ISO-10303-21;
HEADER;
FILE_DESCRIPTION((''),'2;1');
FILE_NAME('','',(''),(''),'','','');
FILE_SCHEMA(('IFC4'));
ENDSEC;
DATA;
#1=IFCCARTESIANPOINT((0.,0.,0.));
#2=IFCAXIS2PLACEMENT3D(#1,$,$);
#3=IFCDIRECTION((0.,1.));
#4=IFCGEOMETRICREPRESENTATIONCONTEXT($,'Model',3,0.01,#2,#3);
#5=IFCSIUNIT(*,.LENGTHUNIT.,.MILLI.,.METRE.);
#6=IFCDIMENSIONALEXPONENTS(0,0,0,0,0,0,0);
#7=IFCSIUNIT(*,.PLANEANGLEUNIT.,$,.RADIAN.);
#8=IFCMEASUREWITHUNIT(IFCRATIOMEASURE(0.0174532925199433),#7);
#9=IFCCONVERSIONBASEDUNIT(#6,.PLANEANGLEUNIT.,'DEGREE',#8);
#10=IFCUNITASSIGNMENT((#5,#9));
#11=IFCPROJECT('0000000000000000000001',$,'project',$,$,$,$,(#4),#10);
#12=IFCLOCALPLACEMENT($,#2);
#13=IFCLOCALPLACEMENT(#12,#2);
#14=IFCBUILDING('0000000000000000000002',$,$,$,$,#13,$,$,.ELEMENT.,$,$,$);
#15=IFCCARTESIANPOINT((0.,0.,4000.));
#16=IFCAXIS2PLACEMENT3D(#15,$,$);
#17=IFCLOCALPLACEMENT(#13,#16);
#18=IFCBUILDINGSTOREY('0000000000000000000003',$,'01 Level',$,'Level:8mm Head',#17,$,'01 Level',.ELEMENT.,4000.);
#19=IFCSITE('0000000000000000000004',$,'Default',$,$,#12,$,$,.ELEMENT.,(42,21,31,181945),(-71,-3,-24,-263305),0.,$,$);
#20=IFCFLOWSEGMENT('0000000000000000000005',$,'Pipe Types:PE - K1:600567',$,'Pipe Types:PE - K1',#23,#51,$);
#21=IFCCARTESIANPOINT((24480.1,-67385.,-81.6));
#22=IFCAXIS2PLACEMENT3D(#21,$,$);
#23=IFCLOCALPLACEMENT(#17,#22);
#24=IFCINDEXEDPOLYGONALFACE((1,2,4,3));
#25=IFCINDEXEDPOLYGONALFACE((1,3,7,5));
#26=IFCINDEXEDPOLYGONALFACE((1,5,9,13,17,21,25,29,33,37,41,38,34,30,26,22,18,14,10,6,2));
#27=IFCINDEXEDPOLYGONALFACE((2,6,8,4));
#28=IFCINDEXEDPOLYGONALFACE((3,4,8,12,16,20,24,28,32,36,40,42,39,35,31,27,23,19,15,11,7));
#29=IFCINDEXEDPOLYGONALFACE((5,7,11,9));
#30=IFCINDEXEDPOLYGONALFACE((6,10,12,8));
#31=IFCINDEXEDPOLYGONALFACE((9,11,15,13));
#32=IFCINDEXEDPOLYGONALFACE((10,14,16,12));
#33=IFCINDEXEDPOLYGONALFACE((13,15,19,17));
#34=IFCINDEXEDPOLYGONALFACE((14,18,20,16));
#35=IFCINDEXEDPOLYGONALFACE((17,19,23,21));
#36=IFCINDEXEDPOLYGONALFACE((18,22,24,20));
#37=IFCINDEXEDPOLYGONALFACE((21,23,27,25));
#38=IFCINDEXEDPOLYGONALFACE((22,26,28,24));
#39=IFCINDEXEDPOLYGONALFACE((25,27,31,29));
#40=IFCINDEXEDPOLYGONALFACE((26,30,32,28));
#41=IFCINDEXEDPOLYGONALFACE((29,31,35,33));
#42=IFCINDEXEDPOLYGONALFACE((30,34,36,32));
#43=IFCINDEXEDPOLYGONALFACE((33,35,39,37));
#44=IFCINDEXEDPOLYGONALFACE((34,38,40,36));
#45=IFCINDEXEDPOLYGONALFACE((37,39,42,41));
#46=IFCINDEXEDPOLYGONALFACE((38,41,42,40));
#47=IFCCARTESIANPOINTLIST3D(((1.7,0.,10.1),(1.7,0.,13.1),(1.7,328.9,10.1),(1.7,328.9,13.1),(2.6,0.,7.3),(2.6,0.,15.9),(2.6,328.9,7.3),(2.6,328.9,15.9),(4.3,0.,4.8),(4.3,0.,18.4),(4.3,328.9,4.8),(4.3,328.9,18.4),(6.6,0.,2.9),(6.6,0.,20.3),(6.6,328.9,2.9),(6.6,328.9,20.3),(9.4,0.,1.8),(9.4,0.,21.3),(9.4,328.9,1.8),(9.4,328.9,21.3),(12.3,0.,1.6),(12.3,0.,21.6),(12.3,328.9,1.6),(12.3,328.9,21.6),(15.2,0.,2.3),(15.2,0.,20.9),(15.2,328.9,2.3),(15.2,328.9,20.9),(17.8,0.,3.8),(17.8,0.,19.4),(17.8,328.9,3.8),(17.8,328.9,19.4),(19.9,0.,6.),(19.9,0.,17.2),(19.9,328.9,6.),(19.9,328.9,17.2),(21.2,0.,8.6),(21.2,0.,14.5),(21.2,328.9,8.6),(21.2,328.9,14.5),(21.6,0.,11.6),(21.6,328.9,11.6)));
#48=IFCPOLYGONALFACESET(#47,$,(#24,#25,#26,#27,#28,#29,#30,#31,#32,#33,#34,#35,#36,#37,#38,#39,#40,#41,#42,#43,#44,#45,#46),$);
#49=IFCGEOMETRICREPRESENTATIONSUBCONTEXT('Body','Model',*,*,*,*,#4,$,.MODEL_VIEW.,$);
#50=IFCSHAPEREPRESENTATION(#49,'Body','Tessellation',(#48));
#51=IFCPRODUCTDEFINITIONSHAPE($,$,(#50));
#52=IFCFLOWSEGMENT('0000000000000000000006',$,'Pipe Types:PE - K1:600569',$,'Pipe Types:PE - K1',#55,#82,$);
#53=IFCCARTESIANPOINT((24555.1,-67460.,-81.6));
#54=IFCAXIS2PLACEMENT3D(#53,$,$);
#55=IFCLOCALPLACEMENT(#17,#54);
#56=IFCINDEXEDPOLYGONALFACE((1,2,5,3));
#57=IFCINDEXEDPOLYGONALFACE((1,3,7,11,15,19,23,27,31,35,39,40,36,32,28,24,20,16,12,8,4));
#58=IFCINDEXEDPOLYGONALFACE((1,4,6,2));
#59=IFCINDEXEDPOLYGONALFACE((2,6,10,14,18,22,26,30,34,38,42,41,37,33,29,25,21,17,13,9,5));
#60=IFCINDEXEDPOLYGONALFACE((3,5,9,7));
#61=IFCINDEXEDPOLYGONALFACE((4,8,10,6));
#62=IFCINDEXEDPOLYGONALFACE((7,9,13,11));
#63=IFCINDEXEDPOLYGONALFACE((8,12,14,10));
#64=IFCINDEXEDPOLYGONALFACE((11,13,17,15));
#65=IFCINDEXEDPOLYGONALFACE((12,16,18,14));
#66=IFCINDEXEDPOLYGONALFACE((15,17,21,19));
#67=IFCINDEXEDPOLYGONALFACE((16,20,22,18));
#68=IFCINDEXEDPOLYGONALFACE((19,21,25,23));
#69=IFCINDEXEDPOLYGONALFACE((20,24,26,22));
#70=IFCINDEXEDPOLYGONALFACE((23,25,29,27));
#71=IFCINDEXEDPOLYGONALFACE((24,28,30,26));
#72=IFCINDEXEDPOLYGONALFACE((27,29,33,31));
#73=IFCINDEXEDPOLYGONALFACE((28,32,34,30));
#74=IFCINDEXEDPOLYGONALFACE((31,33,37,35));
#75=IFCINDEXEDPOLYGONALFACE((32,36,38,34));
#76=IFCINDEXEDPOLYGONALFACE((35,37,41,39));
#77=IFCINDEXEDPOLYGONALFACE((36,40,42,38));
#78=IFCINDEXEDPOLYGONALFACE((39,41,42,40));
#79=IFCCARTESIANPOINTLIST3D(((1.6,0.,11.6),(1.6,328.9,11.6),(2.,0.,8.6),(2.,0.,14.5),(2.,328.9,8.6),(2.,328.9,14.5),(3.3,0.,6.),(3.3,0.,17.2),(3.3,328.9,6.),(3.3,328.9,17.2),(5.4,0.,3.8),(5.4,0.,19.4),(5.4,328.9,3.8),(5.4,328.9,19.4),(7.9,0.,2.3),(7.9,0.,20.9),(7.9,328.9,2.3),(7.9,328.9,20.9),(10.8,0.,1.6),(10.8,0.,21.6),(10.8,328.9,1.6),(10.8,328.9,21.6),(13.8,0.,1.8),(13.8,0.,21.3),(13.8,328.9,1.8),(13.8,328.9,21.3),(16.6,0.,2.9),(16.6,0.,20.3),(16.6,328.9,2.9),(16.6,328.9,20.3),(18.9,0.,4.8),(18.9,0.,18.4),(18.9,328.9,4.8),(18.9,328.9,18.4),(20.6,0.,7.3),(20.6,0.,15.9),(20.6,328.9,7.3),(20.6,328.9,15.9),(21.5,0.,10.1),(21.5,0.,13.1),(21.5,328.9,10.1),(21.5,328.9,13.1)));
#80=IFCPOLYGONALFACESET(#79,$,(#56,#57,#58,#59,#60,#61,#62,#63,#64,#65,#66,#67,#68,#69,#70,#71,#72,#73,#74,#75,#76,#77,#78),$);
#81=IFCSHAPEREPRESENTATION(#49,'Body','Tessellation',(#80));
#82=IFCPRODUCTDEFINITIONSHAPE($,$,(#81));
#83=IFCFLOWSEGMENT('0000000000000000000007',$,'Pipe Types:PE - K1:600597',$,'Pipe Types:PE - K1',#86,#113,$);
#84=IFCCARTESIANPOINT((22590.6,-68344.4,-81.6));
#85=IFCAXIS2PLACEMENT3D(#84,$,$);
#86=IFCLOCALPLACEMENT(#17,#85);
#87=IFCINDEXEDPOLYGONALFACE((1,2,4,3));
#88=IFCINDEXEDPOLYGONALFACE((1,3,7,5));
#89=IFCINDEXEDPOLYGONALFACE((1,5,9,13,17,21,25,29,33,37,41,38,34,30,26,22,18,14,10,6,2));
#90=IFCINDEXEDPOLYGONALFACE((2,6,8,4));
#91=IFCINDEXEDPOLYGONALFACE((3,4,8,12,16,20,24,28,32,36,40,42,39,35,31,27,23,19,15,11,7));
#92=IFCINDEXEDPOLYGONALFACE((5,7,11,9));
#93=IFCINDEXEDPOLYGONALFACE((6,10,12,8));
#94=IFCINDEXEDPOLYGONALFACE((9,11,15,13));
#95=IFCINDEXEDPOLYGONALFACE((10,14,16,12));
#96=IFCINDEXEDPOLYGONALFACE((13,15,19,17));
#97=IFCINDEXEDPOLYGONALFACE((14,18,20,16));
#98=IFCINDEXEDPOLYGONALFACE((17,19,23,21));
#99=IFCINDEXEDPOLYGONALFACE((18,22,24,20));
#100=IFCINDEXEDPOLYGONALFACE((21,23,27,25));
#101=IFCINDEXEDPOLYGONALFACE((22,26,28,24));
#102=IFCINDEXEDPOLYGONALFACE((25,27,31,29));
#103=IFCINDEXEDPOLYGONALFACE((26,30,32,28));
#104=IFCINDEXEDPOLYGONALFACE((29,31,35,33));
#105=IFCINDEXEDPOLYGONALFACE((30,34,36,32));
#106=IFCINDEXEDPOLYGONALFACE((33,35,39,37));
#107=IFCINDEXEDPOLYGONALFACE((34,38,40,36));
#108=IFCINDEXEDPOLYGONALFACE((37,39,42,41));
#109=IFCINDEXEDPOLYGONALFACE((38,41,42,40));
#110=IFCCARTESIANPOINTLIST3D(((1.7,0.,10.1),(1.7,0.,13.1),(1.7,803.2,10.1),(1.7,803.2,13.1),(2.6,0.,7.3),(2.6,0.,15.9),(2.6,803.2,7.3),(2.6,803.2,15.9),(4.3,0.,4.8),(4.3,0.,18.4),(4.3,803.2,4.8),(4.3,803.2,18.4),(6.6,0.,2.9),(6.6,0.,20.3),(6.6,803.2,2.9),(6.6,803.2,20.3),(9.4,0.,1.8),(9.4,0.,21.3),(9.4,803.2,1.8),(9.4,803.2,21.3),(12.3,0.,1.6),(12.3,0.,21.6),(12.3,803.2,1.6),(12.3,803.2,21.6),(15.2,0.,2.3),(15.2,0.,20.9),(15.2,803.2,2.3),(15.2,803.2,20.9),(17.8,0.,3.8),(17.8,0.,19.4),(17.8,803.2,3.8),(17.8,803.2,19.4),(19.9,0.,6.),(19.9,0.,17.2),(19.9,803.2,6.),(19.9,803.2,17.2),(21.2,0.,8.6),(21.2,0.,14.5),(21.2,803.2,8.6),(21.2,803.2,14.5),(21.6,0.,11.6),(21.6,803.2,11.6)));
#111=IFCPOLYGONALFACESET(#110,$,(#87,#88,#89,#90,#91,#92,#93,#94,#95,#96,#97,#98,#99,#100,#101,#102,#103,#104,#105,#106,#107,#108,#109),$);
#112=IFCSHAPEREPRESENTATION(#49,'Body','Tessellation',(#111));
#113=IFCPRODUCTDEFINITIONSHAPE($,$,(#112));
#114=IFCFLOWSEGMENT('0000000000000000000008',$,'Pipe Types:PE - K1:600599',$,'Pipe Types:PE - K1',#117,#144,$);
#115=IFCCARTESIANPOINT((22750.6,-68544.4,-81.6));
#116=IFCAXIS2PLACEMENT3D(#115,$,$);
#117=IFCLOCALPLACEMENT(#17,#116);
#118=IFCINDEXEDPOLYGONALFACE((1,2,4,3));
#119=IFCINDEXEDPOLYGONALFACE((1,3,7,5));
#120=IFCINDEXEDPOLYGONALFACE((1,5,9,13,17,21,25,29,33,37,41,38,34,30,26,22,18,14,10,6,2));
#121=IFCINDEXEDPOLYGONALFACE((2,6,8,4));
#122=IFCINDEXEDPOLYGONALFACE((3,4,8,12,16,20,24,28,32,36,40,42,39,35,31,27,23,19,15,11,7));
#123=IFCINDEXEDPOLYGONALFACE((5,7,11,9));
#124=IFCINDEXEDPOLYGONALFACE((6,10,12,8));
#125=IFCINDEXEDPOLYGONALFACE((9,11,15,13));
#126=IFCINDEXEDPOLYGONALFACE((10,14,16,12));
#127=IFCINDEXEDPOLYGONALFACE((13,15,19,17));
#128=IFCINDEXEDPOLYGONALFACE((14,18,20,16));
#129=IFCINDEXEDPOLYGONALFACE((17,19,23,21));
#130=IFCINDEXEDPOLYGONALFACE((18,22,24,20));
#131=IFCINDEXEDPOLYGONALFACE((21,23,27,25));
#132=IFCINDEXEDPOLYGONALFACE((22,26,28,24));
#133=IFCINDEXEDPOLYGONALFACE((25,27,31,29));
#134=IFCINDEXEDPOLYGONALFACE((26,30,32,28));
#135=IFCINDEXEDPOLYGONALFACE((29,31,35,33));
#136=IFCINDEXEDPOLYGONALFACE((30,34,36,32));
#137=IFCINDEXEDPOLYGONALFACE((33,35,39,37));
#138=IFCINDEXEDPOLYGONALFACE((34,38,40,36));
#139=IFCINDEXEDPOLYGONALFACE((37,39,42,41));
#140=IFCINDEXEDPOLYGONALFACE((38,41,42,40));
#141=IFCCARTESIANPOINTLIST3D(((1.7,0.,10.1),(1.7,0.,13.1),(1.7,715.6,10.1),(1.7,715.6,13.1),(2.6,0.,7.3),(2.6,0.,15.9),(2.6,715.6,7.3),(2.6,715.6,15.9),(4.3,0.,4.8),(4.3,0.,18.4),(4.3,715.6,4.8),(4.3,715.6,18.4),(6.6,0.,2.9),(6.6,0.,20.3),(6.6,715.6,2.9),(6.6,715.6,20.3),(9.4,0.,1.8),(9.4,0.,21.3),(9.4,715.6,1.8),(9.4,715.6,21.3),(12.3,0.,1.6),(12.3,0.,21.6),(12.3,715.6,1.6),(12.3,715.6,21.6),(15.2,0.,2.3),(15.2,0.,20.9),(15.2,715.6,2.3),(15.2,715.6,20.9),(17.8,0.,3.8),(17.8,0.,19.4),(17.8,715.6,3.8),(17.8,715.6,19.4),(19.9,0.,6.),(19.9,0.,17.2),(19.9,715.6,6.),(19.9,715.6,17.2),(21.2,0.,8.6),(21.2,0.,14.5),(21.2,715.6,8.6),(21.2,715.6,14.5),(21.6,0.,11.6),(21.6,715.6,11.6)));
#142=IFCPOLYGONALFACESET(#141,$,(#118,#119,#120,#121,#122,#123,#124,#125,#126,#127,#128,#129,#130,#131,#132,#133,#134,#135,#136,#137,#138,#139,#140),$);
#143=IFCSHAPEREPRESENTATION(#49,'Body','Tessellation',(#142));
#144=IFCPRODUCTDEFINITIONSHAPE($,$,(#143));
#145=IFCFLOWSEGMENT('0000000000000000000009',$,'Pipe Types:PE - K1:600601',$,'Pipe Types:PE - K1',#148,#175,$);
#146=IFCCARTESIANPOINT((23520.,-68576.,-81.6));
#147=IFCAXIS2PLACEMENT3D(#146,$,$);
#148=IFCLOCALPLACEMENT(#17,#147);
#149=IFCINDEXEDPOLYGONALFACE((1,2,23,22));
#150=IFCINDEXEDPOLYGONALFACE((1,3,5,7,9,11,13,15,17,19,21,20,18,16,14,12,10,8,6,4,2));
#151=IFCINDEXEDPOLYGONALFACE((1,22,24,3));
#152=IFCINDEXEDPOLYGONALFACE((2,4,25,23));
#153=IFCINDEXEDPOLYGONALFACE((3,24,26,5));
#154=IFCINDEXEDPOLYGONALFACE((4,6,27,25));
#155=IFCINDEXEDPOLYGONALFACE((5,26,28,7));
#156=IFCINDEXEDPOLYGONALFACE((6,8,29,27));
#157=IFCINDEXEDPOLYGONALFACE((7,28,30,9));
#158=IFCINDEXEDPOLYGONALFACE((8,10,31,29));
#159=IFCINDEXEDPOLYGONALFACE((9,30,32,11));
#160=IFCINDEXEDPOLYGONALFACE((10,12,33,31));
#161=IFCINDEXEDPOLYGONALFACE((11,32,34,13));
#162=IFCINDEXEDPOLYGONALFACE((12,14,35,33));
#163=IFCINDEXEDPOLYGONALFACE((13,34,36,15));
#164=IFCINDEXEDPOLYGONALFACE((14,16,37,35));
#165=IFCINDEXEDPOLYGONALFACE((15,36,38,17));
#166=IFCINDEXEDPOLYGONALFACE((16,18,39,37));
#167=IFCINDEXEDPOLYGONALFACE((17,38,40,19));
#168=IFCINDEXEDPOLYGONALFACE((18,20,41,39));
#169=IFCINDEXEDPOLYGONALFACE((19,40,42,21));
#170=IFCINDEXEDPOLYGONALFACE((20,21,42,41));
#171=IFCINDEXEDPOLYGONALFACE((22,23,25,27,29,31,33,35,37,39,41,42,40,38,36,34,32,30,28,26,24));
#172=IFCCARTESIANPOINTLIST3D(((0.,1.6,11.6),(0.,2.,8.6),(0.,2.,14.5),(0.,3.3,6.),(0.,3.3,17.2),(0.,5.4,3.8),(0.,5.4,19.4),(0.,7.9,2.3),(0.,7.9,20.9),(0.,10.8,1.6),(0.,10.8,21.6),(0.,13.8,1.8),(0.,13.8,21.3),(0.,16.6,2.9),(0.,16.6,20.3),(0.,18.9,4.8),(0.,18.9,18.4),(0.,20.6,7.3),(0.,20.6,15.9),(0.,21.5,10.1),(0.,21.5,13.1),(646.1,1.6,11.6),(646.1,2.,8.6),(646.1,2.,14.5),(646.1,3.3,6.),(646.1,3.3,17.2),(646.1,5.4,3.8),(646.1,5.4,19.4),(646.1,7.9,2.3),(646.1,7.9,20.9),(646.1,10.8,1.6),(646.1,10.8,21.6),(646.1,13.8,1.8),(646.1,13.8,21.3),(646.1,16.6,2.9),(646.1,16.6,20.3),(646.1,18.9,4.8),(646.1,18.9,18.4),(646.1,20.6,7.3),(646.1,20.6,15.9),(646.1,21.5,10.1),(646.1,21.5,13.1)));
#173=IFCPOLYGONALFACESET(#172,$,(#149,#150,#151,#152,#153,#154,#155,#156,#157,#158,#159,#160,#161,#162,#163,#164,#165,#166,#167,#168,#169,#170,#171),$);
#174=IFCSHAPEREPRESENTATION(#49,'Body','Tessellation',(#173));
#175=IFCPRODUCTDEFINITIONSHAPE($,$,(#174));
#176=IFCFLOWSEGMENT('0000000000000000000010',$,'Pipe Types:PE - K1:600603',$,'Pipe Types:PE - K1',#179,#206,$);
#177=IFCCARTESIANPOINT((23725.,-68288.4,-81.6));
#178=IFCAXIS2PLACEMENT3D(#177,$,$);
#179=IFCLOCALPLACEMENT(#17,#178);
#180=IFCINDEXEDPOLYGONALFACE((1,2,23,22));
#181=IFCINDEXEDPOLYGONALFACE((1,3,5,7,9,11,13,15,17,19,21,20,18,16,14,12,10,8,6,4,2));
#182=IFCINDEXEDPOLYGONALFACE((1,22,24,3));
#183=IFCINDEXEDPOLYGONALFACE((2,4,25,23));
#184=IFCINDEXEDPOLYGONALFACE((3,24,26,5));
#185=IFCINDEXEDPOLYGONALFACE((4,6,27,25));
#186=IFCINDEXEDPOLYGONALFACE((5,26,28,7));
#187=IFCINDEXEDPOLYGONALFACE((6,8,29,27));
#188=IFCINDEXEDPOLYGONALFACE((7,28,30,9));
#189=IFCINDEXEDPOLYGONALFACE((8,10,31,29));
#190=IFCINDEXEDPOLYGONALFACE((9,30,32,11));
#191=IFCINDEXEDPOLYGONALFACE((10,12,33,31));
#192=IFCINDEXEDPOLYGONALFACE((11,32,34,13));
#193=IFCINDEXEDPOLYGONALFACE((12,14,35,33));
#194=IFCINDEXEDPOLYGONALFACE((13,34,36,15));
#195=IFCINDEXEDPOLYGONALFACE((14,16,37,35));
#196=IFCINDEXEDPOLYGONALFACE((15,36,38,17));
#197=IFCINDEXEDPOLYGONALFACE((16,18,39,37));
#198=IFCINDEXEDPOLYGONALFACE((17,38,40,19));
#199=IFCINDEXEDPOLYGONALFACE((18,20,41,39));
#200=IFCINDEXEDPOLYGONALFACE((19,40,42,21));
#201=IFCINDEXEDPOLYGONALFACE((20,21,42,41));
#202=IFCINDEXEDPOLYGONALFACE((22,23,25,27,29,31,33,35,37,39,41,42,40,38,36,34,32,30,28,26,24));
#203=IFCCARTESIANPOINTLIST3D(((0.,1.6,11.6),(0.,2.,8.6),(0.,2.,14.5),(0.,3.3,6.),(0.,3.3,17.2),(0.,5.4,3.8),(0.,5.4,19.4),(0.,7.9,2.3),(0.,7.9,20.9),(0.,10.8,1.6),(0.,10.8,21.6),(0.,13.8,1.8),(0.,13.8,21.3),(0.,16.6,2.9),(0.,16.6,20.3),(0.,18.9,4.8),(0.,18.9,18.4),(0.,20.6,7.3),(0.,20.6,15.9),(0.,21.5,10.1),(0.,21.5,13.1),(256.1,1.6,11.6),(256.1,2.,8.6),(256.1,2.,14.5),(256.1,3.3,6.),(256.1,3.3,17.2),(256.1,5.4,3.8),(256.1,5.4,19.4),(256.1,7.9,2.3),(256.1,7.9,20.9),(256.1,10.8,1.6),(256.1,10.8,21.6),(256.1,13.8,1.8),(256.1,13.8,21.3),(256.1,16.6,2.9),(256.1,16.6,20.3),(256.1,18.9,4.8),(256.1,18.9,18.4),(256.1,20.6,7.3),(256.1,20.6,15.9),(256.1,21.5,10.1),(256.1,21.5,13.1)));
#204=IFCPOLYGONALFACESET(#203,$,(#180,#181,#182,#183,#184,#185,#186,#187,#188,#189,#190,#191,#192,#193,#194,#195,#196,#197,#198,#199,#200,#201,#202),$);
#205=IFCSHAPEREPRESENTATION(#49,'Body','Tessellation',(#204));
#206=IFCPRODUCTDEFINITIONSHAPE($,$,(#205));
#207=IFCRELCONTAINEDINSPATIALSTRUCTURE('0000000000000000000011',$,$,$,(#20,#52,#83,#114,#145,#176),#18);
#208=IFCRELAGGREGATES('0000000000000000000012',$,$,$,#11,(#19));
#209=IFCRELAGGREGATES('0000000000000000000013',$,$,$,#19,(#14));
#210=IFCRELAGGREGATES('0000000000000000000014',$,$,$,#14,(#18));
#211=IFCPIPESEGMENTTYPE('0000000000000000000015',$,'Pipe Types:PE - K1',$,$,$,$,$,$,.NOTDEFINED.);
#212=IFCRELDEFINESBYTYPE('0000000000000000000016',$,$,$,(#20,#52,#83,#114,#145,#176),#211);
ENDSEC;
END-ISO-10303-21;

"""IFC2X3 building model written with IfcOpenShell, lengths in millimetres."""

from ifc_helpers import new_model, entity, si_unit, converted_unit, direction, frame, frame_2d, origin, origin_2d_with_axis, place, context, subcontext, project, spatial, circle, extrude, type_object, element, save


model = new_model("IFC2X3")

# Units and contexts
model_context = context("Model", 3, precision=0.01, world=origin(), true_north=direction((0.0, 1.0)))
body_context = subcontext(model_context, "Body", "Model", "MODEL_VIEW")
ifc_project = project(units=[si_unit("LENGTHUNIT", "METRE", prefix="MILLI"), converted_unit("PLANEANGLEUNIT", "DEGREE", entity("IfcRatioMeasure", 0.0174532925199433), si_unit("PLANEANGLEUNIT", "RADIAN"), dimensions=[0, 0, 0, 0, 0, 0, 0])], contexts=[model_context])

# Site, building, storey
site_placement = place(None, origin())
site = spatial("IfcSite", under=ifc_project, at=site_placement, Name="Default", CompositionType="ELEMENT", RefLatitude=(42, 21, 31, 181945), RefLongitude=(-71, -3, -24, -263305), RefElevation=0.0)
building_placement = place(site_placement, origin())
building = spatial("IfcBuilding", under=site, at=building_placement, CompositionType="ELEMENT")
storey_placement = place(building_placement, frame((0.0, 0.0, 4000.0)))
storey = spatial("IfcBuildingStorey", under=building, at=storey_placement, Name="01 Level", ObjectType="Level:8mm Head", LongName="01 Level", CompositionType="ELEMENT", Elevation=4000.0)

# Flow segments
pipe_segment_type = type_object("IfcPipeSegmentType", Name="Pipe Types:PE - K1", PredefinedType="NOTDEFINED")
flow_segment_1_placement = place(storey_placement, frame((24480.1, -67385.0, -81.6)))
element("IfcFlowSegment", 1, at=flow_segment_1_placement, inside=storey, type_object=pipe_segment_type, Name="Pipe Types:PE - K1:600567", ObjectType="Pipe Types:PE - K1", context=body_context, shape_type="SweptSolid", body=[
    extrude(circle(Radius=10.0, at=origin_2d_with_axis()), frame((11.6, 0.0, 11.6), z_axis=(0.0, 1.0, 0.0), x_axis=(1.0, 0.0, 0.0)), (0.0, 0.0, 1.0), 328.9),
])
flow_segment_2_placement = place(storey_placement, frame((24555.1, -67460.0, -81.6)))
element("IfcFlowSegment", 2, at=flow_segment_2_placement, inside=storey, type_object=pipe_segment_type, Name="Pipe Types:PE - K1:600569", ObjectType="Pipe Types:PE - K1", context=body_context, shape_type="SweptSolid", body=[
    extrude(circle(Radius=10.0, at=frame_2d((0.0, 0.0), x_axis=(1.0, 0.0))), frame((11.6, 0.0, 11.6), z_axis=(0.0, 1.0, 0.0), x_axis=(-1.0, 0.0, 0.0)), (0.0, 0.0, 1.0), 328.9),
])
flow_segment_3_placement = place(storey_placement, frame((22590.6, -68344.4, -81.6)))
element("IfcFlowSegment", 3, at=flow_segment_3_placement, inside=storey, type_object=pipe_segment_type, Name="Pipe Types:PE - K1:600597", ObjectType="Pipe Types:PE - K1", context=body_context, shape_type="SweptSolid", body=[
    extrude(circle(Radius=10.0, at=origin_2d_with_axis()), frame((11.6, 0.0, 11.6), z_axis=(0.0, 1.0, 0.0), x_axis=(1.0, 0.0, 0.0)), (0.0, 0.0, 1.0), 803.2),
])
flow_segment_4_placement = place(storey_placement, frame((22750.6, -68544.4, -81.6)))
element("IfcFlowSegment", 4, at=flow_segment_4_placement, inside=storey, type_object=pipe_segment_type, Name="Pipe Types:PE - K1:600599", ObjectType="Pipe Types:PE - K1", context=body_context, shape_type="SweptSolid", body=[
    extrude(circle(Radius=10.0, at=origin_2d_with_axis()), frame((11.6, 0.0, 11.6), z_axis=(0.0, 1.0, 0.0), x_axis=(1.0, 0.0, 0.0)), (0.0, 0.0, 1.0), 715.6),
])
flow_segment_5_placement = place(storey_placement, frame((23520.0, -68576.0, -81.6)))
element("IfcFlowSegment", 5, at=flow_segment_5_placement, inside=storey, type_object=pipe_segment_type, Name="Pipe Types:PE - K1:600601", ObjectType="Pipe Types:PE - K1", context=body_context, shape_type="SweptSolid", body=[
    extrude(circle(Radius=10.0, at=origin_2d_with_axis()), frame((0.0, 11.6, 11.6), z_axis=(1.0, 0.0, 0.0), x_axis=(0.0, -1.0, 0.0)), (0.0, 0.0, 1.0), 646.1),
])
flow_segment_6_placement = place(storey_placement, frame((23725.0, -68288.4, -81.6)))
element("IfcFlowSegment", 6, at=flow_segment_6_placement, inside=storey, type_object=pipe_segment_type, Name="Pipe Types:PE - K1:600603", ObjectType="Pipe Types:PE - K1", context=body_context, shape_type="SweptSolid", body=[
    extrude(circle(Radius=10.0, at=origin_2d_with_axis()), frame((0.0, 11.6, 11.6), z_axis=(1.0, 0.0, 0.0), x_axis=(0.0, -1.0, 0.0)), (0.0, 0.0, 1.0), 256.1),
])

save(model, "model.ifc")
